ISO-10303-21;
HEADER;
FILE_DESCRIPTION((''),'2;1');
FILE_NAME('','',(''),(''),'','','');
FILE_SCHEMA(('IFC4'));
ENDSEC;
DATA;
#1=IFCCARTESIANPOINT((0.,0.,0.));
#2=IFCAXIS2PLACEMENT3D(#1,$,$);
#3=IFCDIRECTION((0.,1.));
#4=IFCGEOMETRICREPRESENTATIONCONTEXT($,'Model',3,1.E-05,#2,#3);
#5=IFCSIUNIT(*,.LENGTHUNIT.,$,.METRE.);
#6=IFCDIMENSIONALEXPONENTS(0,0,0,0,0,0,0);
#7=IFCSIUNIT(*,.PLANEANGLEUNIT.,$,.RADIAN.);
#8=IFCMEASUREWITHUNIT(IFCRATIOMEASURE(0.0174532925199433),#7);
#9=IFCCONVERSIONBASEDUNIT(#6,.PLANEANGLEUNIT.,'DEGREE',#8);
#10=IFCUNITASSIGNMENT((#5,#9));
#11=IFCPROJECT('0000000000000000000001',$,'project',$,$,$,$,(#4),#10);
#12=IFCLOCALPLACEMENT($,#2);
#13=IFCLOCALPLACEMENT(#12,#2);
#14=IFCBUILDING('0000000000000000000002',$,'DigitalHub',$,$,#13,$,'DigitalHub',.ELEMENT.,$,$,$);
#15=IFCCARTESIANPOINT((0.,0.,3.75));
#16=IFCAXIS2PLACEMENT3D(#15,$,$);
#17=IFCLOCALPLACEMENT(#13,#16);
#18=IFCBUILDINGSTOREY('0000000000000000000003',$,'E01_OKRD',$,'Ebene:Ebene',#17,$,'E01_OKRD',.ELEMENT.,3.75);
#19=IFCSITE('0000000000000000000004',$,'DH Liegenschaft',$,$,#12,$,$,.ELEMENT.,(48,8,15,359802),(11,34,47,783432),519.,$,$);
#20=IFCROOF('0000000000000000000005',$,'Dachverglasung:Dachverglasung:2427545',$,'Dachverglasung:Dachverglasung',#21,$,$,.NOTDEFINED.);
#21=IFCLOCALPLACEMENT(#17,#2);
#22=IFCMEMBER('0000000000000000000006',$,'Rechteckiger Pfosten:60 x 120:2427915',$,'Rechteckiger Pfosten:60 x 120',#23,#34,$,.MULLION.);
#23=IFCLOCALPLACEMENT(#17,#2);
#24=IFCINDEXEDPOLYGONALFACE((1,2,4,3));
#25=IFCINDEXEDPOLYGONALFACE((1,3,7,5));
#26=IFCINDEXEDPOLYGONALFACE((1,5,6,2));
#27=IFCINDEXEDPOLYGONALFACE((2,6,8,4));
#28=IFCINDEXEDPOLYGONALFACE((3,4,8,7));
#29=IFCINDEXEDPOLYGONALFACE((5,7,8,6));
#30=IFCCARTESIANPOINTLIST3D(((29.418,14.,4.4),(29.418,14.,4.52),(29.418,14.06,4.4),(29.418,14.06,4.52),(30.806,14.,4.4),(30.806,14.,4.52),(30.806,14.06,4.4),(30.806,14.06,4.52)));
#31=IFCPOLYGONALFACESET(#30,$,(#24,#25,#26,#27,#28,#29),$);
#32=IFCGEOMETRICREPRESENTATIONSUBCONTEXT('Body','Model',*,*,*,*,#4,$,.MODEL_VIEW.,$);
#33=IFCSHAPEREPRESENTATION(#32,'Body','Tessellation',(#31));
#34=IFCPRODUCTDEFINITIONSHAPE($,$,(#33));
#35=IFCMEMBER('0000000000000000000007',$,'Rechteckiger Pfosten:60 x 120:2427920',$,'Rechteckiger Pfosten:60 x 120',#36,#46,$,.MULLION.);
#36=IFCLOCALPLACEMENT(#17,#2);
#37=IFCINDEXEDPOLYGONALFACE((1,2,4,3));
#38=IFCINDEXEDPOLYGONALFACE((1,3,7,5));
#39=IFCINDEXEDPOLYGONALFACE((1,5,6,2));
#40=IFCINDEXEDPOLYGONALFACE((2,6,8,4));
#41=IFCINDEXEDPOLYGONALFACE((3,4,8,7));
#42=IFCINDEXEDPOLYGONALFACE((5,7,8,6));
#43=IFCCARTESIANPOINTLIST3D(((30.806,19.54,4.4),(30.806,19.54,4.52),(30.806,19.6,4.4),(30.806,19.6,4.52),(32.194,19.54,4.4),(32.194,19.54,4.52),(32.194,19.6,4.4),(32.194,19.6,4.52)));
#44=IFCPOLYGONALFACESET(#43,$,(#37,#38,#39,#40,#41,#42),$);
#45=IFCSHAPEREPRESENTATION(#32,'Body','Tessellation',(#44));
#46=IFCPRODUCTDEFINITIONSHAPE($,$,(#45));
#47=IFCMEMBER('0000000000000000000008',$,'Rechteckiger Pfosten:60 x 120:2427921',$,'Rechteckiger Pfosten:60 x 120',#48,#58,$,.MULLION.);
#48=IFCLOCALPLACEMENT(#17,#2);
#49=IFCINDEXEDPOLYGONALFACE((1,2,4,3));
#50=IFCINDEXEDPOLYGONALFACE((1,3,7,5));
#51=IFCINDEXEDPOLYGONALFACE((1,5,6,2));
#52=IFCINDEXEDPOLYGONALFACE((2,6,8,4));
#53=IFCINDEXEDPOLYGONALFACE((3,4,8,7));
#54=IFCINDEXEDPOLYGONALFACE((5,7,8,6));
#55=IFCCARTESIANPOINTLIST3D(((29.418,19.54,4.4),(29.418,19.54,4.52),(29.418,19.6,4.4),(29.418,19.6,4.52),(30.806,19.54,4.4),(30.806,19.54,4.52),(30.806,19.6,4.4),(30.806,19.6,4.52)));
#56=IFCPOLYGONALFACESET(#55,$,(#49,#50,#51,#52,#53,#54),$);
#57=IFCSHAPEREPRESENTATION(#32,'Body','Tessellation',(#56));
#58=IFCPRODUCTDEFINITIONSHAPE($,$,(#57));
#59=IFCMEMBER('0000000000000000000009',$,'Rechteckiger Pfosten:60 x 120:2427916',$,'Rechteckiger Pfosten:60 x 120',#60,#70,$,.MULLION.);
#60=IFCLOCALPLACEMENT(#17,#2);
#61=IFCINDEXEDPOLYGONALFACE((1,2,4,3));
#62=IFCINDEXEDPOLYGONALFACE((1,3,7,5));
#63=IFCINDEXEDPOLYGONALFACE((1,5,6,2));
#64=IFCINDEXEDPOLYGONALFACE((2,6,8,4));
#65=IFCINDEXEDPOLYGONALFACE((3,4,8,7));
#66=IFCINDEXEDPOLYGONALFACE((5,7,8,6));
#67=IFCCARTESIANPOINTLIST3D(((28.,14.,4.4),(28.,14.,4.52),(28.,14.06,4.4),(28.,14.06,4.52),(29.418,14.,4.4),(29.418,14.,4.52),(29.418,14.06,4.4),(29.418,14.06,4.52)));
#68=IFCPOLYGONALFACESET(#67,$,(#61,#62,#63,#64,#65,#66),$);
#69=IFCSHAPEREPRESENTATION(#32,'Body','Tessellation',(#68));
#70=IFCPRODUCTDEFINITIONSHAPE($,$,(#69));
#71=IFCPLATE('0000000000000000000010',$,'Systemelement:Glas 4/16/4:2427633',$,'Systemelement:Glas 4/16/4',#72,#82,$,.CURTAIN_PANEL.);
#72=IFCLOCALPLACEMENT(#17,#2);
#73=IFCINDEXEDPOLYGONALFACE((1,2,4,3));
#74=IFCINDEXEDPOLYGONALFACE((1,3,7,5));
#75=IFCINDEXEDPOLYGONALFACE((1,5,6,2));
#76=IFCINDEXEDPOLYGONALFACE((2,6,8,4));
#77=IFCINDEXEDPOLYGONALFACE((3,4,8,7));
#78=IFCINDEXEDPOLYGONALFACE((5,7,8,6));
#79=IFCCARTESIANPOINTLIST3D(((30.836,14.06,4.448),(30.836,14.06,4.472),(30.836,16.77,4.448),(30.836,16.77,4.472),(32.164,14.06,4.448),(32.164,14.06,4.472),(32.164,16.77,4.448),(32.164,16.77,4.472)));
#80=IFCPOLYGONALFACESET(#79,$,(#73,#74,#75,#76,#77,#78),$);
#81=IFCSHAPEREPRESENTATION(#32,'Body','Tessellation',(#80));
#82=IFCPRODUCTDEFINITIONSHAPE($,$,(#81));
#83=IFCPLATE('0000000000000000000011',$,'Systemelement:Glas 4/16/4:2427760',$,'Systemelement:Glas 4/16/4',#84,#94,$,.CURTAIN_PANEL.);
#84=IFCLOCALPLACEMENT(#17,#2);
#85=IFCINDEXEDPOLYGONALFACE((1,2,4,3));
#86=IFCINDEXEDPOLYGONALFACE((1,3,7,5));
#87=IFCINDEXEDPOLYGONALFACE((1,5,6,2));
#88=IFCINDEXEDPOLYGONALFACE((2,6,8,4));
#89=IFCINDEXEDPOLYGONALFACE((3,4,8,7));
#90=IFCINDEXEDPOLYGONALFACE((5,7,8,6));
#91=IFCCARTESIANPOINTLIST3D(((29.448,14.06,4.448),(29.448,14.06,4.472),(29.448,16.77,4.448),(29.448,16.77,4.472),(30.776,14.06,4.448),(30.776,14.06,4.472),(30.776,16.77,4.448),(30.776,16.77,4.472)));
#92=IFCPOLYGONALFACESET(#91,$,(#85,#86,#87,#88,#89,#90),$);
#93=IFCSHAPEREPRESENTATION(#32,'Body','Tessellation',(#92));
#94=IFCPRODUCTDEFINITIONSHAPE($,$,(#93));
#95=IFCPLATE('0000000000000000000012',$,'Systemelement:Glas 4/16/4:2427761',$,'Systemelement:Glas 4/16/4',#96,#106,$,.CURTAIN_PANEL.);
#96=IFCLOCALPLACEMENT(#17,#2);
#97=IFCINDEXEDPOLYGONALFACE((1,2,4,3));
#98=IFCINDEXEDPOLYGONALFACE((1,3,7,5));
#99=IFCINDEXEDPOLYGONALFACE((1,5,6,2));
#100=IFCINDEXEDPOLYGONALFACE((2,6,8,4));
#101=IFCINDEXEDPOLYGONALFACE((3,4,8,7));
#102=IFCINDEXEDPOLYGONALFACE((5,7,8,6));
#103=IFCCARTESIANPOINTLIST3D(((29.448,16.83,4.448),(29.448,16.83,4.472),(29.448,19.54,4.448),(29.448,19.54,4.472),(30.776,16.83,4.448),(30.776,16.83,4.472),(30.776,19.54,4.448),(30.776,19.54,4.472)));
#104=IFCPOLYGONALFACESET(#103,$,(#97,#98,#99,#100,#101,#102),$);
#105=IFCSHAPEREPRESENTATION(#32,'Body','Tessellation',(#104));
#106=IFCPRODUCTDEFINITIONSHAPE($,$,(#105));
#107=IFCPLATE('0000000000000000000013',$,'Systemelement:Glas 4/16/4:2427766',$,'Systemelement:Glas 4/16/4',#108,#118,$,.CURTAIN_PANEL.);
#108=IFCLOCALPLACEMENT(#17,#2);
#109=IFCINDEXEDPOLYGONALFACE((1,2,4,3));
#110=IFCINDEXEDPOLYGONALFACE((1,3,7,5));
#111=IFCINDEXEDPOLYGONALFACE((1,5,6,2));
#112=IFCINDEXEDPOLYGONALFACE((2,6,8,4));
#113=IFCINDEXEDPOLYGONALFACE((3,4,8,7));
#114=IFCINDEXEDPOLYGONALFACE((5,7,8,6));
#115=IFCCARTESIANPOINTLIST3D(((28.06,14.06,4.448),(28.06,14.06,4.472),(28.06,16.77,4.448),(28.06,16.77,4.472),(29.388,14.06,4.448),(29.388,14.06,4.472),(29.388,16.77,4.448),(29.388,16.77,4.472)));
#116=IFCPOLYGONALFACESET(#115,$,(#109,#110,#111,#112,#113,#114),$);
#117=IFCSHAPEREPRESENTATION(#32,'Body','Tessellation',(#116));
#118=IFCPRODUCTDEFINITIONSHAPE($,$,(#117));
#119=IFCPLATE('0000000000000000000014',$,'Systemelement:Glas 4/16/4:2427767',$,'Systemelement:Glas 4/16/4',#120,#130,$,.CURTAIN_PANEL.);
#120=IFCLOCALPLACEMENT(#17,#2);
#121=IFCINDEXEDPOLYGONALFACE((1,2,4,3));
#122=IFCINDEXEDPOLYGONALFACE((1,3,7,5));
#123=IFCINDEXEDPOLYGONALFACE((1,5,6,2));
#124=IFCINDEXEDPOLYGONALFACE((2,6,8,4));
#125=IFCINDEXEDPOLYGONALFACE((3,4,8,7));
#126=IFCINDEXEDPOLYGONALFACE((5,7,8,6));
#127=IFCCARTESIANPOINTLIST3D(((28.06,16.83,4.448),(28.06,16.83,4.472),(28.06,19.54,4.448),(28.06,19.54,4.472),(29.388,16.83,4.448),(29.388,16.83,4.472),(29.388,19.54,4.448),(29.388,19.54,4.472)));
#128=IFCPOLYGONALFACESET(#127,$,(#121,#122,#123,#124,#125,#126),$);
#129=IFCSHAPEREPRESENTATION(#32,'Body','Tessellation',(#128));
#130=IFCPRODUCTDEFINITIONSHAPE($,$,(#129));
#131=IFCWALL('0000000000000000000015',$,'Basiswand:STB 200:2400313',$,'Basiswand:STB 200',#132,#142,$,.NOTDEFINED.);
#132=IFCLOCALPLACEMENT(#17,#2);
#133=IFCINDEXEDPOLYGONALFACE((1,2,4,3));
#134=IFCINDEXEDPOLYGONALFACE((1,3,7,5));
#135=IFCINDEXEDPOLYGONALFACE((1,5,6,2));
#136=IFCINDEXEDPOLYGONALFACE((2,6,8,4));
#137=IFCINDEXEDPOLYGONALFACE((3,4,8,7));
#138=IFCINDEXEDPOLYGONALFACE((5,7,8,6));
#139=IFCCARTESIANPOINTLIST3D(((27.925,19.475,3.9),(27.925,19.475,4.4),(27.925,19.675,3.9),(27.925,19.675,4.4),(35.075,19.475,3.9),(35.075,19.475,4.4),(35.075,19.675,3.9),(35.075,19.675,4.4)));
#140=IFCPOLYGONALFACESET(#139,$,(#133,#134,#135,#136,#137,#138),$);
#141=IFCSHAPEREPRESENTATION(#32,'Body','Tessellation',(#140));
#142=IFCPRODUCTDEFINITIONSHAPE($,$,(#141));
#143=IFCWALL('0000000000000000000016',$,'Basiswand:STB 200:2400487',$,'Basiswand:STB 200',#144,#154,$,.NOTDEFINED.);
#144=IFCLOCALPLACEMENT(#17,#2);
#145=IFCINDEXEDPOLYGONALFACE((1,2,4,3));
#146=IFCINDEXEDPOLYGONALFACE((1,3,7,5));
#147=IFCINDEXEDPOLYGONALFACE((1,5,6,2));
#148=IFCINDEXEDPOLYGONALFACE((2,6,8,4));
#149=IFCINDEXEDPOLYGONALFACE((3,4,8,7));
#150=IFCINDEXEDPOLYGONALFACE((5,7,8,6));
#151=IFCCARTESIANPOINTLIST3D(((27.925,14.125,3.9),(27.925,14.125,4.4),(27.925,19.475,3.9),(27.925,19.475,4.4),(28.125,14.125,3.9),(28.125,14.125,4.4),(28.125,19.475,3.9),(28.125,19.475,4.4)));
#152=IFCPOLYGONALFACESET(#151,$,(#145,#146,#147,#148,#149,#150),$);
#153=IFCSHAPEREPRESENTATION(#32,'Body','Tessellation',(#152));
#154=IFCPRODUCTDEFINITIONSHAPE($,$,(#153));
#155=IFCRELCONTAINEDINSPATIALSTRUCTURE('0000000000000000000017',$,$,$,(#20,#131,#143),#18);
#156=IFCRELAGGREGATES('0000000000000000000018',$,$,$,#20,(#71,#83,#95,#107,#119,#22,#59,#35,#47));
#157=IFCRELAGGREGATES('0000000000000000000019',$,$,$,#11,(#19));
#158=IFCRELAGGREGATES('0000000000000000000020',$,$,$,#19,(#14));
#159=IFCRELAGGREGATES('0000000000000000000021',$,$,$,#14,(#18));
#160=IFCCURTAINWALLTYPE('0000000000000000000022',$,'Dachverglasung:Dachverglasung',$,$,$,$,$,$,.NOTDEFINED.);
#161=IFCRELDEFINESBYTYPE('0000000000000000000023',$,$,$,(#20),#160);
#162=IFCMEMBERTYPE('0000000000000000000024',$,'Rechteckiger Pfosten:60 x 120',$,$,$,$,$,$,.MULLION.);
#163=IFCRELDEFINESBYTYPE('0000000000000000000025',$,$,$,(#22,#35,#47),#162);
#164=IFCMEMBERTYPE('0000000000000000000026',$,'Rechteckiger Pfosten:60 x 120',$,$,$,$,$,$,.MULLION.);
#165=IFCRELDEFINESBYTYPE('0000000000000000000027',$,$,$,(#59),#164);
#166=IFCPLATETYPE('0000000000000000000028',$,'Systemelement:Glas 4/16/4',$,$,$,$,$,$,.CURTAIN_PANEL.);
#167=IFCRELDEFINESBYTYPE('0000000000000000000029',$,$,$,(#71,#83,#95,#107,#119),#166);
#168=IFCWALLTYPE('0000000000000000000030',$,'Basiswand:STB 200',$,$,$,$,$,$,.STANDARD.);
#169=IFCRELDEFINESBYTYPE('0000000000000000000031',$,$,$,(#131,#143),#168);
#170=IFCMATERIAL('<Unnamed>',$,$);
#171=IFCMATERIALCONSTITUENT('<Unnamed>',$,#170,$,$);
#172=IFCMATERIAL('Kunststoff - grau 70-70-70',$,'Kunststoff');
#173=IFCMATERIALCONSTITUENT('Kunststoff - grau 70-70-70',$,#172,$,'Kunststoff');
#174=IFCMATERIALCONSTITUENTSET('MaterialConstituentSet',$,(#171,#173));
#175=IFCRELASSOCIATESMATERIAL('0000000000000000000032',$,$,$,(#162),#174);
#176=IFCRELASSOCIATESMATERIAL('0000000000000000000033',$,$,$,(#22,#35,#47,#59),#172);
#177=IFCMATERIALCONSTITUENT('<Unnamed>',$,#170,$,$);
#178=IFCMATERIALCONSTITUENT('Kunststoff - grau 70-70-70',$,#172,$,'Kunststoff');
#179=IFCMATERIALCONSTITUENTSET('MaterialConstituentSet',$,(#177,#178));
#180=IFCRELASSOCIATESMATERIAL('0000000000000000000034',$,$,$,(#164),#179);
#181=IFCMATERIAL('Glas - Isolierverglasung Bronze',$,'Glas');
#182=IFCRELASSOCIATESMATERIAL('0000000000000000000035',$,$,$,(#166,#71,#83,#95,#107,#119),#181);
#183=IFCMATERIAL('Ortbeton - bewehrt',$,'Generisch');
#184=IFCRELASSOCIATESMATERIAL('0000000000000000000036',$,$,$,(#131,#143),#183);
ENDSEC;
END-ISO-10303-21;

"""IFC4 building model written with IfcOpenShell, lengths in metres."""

from ifc_helpers import new_model, entity, si_unit, converted_unit, direction, frame, origin, place, context, subcontext, project, spatial, indexed_curve, outline, extrude, source, transform, mapped, material, constituent, constituent_set, type_object, type_shapes, element, aggregate, save


model = new_model("IFC4")

# Units and contexts
model_context = context("Model", 3, precision=1e-05, world=origin(), true_north=direction((0.0, 1.0)))
body_context = subcontext(model_context, "Body", "Model", "MODEL_VIEW")
ifc_project = project(units=[si_unit("LENGTHUNIT", "METRE"), converted_unit("PLANEANGLEUNIT", "DEGREE", entity("IfcRatioMeasure", 0.0174532925199433), si_unit("PLANEANGLEUNIT", "RADIAN"), dimensions=[0, 0, 0, 0, 0, 0, 0])], contexts=[model_context])

# Site, building, storey
site_placement = place(None, frame((0.0, 0.0, 0.0)))
site = spatial("IfcSite", under=ifc_project, at=site_placement, Name="DH Liegenschaft", CompositionType="ELEMENT", RefLatitude=(48, 8, 15, 359802), RefLongitude=(11, 34, 47, 783432), RefElevation=519.0)
building_placement = place(site_placement, origin())
building = spatial("IfcBuilding", under=site, at=building_placement, Name="DigitalHub", LongName="DigitalHub", CompositionType="ELEMENT")
storey_placement = place(building_placement, frame((0.0, 0.0, 3.75)))
storey = spatial("IfcBuildingStorey", under=building, at=storey_placement, Name="E01_OKRD", ObjectType="Ebene:Ebene", LongName="E01_OKRD", CompositionType="ELEMENT", Elevation=3.75)

# Roof, members, plates
curtain_wall_type = type_object("IfcCurtainWallType", Name="Dachverglasung:Dachverglasung", PredefinedType="NOTDEFINED")
roof_placement = place(storey_placement, frame((0.0, 0.0, -3.75)))
roof = element("IfcRoof", 1, at=roof_placement, inside=storey, type_object=curtain_wall_type, Name="Dachverglasung:Dachverglasung:2427545", ObjectType="Dachverglasung:Dachverglasung", PredefinedType="NOTDEFINED")
ifc_material_1 = material(Name="Kunststoff - grau 70-70-70", Category="Kunststoff")
ifc_material_2 = material(Name="<Unnamed>")
ifc_constituent_1 = constituent(ifc_material_2, Name="<Unnamed>")
ifc_constituent_2 = constituent(ifc_material_1, Name="Kunststoff - grau 70-70-70", Category="Kunststoff")
ifc_constituent_set_1 = constituent_set(constituents=[ifc_constituent_1, ifc_constituent_2], Name="MaterialConstituentSet")
member_type_1 = type_object("IfcMemberType", Name="Rechteckiger Pfosten:60 x 120", PredefinedType="MULLION", material=ifc_constituent_set_1)
shared_shape_1 = source(origin(), body_context, "Body", "SweptSolid", [
    extrude(outline(indexed_curve([(-0.06, -0.03), (0.06, -0.03), (0.06, 0.03), (-0.06, 0.03), (-0.06, -0.03)], self_intersect=False)), frame((-0.03, 0.0, -1.388), z_axis=(0.0, 0.0, 1.0), x_axis=(0.0, -1.0, 0.0)), (0.0, 0.0, 1.0), 1.388),
])
type_shapes(member_type_1, [shared_shape_1])
member_1_placement = place(storey_placement, frame((30.806, 14.0, 4.46), z_axis=(1.0, 0.0, 0.0), x_axis=(0.0, -1.0, 0.0)))
member_1 = element("IfcMember", 2, at=member_1_placement, type_object=member_type_1, material=ifc_material_1, Name="Rechteckiger Pfosten:60 x 120:2427915", ObjectType="Rechteckiger Pfosten:60 x 120", PredefinedType="MULLION", context=body_context, shape_type="MappedRepresentation", body=[
    mapped(shared_shape_1, transform((0.0, 0.0, 0.0), scale=1.0)),
])
member_2_placement = place(storey_placement, frame((30.806, 19.6, 4.46), z_axis=(-1.0, 0.0, 0.0), x_axis=(0.0, 1.0, 0.0)))
member_2 = element("IfcMember", 3, at=member_2_placement, type_object=member_type_1, material=ifc_material_1, Name="Rechteckiger Pfosten:60 x 120:2427920", ObjectType="Rechteckiger Pfosten:60 x 120", PredefinedType="MULLION", context=body_context, shape_type="MappedRepresentation", body=[
    mapped(shared_shape_1, transform((0.0, 0.0, 0.0), scale=1.0)),
])
member_3_placement = place(storey_placement, frame((29.418, 19.6, 4.46), z_axis=(-1.0, 0.0, 0.0), x_axis=(0.0, 1.0, 0.0)))
member_3 = element("IfcMember", 4, at=member_3_placement, type_object=member_type_1, material=ifc_material_1, Name="Rechteckiger Pfosten:60 x 120:2427921", ObjectType="Rechteckiger Pfosten:60 x 120", PredefinedType="MULLION", context=body_context, shape_type="MappedRepresentation", body=[
    mapped(shared_shape_1, transform((0.0, 0.0, 0.0), scale=1.0)),
])
ifc_constituent_3 = constituent(ifc_material_2, Name="<Unnamed>")
ifc_constituent_4 = constituent(ifc_material_1, Name="Kunststoff - grau 70-70-70", Category="Kunststoff")
ifc_constituent_set_2 = constituent_set(constituents=[ifc_constituent_3, ifc_constituent_4], Name="MaterialConstituentSet")
member_type_2 = type_object("IfcMemberType", Name="Rechteckiger Pfosten:60 x 120", PredefinedType="MULLION", material=ifc_constituent_set_2)
shared_shape_2 = source(origin(), body_context, "Body", "SweptSolid", [
    extrude(outline(indexed_curve([(-0.06, -0.03), (0.06, -0.03), (0.06, 0.03), (-0.06, 0.03), (-0.06, -0.03)], self_intersect=False)), frame((-0.03, 0.0, -1.418), z_axis=(0.0, 0.0, 1.0), x_axis=(0.0, -1.0, 0.0)), (0.0, 0.0, 1.0), 1.418),
])
type_shapes(member_type_2, [shared_shape_2])
member_4_placement = place(storey_placement, frame((29.418, 14.0, 4.46), z_axis=(1.0, 0.0, 0.0), x_axis=(0.0, -1.0, 0.0)))
member_4 = element("IfcMember", 5, at=member_4_placement, type_object=member_type_2, material=ifc_material_1, Name="Rechteckiger Pfosten:60 x 120:2427916", ObjectType="Rechteckiger Pfosten:60 x 120", PredefinedType="MULLION", context=body_context, shape_type="MappedRepresentation", body=[
    mapped(shared_shape_2, transform((0.0, 0.0, 0.0), scale=1.0)),
])
ifc_material_3 = material(Name="Glas - Isolierverglasung Bronze", Category="Glas")
plate_type = type_object("IfcPlateType", Name="Systemelement:Glas 4/16/4", PredefinedType="CURTAIN_PANEL", material=ifc_material_3)
shared_shape_3 = source(origin(), body_context, "Body", "SweptSolid", [
    extrude(outline(indexed_curve([(-0.012, -1.355), (0.012, -1.355), (0.012, 1.355), (-0.012, 1.355), (-0.012, -1.355)], self_intersect=False)), frame((0.0, 0.0, 0.0), z_axis=(0.0, 0.0, 1.0), x_axis=(0.0, 1.0, 0.0)), (0.0, 0.0, 1.0), 1.328),
])
type_shapes(plate_type, [shared_shape_3])
plate_1_placement = place(roof_placement, frame((32.164, 15.415, 8.21), z_axis=(-1.0, 0.0, 0.0), x_axis=(0.0, 1.0, 0.0)))
plate_1 = element("IfcPlate", 6, at=plate_1_placement, type_object=plate_type, material=ifc_material_3, Name="Systemelement:Glas 4/16/4:2427633", ObjectType="Systemelement:Glas 4/16/4", PredefinedType="CURTAIN_PANEL", context=body_context, shape_type="MappedRepresentation", body=[
    mapped(shared_shape_3, transform((0.0, 0.0, 0.0), scale=1.0)),
])
plate_2_placement = place(roof_placement, frame((30.776, 15.415, 8.21), z_axis=(-1.0, 0.0, 0.0), x_axis=(0.0, 1.0, 0.0)))
plate_2 = element("IfcPlate", 7, at=plate_2_placement, type_object=plate_type, material=ifc_material_3, Name="Systemelement:Glas 4/16/4:2427760", ObjectType="Systemelement:Glas 4/16/4", PredefinedType="CURTAIN_PANEL", context=body_context, shape_type="MappedRepresentation", body=[
    mapped(shared_shape_3, transform((0.0, 0.0, 0.0), scale=1.0)),
])
plate_3_placement = place(roof_placement, frame((30.776, 18.185, 8.21), z_axis=(-1.0, 0.0, 0.0), x_axis=(0.0, 1.0, 0.0)))
plate_3 = element("IfcPlate", 8, at=plate_3_placement, type_object=plate_type, material=ifc_material_3, Name="Systemelement:Glas 4/16/4:2427761", ObjectType="Systemelement:Glas 4/16/4", PredefinedType="CURTAIN_PANEL", context=body_context, shape_type="MappedRepresentation", body=[
    mapped(shared_shape_3, transform((0.0, 0.0, 0.0), scale=1.0)),
])
plate_4_placement = place(roof_placement, frame((29.388, 15.415, 8.21), z_axis=(-1.0, 0.0, 0.0), x_axis=(0.0, 1.0, 0.0)))
plate_4 = element("IfcPlate", 9, at=plate_4_placement, type_object=plate_type, material=ifc_material_3, Name="Systemelement:Glas 4/16/4:2427766", ObjectType="Systemelement:Glas 4/16/4", PredefinedType="CURTAIN_PANEL", context=body_context, shape_type="MappedRepresentation", body=[
    mapped(shared_shape_3, transform((0.0, 0.0, 0.0), scale=1.0)),
])
plate_5_placement = place(roof_placement, frame((29.388, 18.185, 8.21), z_axis=(-1.0, 0.0, 0.0), x_axis=(0.0, 1.0, 0.0)))
plate_5 = element("IfcPlate", 10, at=plate_5_placement, type_object=plate_type, material=ifc_material_3, Name="Systemelement:Glas 4/16/4:2427767", ObjectType="Systemelement:Glas 4/16/4", PredefinedType="CURTAIN_PANEL", context=body_context, shape_type="MappedRepresentation", body=[
    mapped(shared_shape_3, transform((0.0, 0.0, 0.0), scale=1.0)),
])
aggregate(roof, [plate_1, plate_2, plate_3, plate_4, plate_5, member_1, member_4, member_2, member_3])

# Walls
ifc_material_4 = material(Name="Ortbeton - bewehrt", Category="Generisch")
wall_type_1 = type_object("IfcWallType", Name="Basiswand:STB 200", PredefinedType="STANDARD")
wall_1_placement = place(storey_placement, frame((27.925, 19.575, 3.9)))
element("IfcWall", 11, at=wall_1_placement, inside=storey, type_object=wall_type_1, material=ifc_material_4, Name="Basiswand:STB 200:2400313", ObjectType="Basiswand:STB 200", PredefinedType="NOTDEFINED", context=body_context, shape_type="SweptSolid", body=[
    extrude(outline(indexed_curve([(7.15, 0.1), (0.0, 0.1), (0.0, -0.1), (7.15, -0.1), (7.15, 0.1)], self_intersect=False)), origin(), (0.0, 0.0, 1.0), 0.5),
])
wall_2_placement = place(storey_placement, frame((28.025, 14.125, 3.9), z_axis=(0.0, 0.0, 1.0), x_axis=(0.0, 1.0, 0.0)))
element("IfcWall", 12, at=wall_2_placement, inside=storey, type_object=wall_type_1, material=ifc_material_4, Name="Basiswand:STB 200:2400487", ObjectType="Basiswand:STB 200", PredefinedType="NOTDEFINED", context=body_context, shape_type="SweptSolid", body=[
    extrude(outline(indexed_curve([(5.35, 0.1), (0.0, 0.1), (0.0, -0.1), (5.35, -0.1), (5.35, 0.1)], self_intersect=False)), origin(), (0.0, 0.0, 1.0), 0.5),
])

save(model, "model.ifc")
